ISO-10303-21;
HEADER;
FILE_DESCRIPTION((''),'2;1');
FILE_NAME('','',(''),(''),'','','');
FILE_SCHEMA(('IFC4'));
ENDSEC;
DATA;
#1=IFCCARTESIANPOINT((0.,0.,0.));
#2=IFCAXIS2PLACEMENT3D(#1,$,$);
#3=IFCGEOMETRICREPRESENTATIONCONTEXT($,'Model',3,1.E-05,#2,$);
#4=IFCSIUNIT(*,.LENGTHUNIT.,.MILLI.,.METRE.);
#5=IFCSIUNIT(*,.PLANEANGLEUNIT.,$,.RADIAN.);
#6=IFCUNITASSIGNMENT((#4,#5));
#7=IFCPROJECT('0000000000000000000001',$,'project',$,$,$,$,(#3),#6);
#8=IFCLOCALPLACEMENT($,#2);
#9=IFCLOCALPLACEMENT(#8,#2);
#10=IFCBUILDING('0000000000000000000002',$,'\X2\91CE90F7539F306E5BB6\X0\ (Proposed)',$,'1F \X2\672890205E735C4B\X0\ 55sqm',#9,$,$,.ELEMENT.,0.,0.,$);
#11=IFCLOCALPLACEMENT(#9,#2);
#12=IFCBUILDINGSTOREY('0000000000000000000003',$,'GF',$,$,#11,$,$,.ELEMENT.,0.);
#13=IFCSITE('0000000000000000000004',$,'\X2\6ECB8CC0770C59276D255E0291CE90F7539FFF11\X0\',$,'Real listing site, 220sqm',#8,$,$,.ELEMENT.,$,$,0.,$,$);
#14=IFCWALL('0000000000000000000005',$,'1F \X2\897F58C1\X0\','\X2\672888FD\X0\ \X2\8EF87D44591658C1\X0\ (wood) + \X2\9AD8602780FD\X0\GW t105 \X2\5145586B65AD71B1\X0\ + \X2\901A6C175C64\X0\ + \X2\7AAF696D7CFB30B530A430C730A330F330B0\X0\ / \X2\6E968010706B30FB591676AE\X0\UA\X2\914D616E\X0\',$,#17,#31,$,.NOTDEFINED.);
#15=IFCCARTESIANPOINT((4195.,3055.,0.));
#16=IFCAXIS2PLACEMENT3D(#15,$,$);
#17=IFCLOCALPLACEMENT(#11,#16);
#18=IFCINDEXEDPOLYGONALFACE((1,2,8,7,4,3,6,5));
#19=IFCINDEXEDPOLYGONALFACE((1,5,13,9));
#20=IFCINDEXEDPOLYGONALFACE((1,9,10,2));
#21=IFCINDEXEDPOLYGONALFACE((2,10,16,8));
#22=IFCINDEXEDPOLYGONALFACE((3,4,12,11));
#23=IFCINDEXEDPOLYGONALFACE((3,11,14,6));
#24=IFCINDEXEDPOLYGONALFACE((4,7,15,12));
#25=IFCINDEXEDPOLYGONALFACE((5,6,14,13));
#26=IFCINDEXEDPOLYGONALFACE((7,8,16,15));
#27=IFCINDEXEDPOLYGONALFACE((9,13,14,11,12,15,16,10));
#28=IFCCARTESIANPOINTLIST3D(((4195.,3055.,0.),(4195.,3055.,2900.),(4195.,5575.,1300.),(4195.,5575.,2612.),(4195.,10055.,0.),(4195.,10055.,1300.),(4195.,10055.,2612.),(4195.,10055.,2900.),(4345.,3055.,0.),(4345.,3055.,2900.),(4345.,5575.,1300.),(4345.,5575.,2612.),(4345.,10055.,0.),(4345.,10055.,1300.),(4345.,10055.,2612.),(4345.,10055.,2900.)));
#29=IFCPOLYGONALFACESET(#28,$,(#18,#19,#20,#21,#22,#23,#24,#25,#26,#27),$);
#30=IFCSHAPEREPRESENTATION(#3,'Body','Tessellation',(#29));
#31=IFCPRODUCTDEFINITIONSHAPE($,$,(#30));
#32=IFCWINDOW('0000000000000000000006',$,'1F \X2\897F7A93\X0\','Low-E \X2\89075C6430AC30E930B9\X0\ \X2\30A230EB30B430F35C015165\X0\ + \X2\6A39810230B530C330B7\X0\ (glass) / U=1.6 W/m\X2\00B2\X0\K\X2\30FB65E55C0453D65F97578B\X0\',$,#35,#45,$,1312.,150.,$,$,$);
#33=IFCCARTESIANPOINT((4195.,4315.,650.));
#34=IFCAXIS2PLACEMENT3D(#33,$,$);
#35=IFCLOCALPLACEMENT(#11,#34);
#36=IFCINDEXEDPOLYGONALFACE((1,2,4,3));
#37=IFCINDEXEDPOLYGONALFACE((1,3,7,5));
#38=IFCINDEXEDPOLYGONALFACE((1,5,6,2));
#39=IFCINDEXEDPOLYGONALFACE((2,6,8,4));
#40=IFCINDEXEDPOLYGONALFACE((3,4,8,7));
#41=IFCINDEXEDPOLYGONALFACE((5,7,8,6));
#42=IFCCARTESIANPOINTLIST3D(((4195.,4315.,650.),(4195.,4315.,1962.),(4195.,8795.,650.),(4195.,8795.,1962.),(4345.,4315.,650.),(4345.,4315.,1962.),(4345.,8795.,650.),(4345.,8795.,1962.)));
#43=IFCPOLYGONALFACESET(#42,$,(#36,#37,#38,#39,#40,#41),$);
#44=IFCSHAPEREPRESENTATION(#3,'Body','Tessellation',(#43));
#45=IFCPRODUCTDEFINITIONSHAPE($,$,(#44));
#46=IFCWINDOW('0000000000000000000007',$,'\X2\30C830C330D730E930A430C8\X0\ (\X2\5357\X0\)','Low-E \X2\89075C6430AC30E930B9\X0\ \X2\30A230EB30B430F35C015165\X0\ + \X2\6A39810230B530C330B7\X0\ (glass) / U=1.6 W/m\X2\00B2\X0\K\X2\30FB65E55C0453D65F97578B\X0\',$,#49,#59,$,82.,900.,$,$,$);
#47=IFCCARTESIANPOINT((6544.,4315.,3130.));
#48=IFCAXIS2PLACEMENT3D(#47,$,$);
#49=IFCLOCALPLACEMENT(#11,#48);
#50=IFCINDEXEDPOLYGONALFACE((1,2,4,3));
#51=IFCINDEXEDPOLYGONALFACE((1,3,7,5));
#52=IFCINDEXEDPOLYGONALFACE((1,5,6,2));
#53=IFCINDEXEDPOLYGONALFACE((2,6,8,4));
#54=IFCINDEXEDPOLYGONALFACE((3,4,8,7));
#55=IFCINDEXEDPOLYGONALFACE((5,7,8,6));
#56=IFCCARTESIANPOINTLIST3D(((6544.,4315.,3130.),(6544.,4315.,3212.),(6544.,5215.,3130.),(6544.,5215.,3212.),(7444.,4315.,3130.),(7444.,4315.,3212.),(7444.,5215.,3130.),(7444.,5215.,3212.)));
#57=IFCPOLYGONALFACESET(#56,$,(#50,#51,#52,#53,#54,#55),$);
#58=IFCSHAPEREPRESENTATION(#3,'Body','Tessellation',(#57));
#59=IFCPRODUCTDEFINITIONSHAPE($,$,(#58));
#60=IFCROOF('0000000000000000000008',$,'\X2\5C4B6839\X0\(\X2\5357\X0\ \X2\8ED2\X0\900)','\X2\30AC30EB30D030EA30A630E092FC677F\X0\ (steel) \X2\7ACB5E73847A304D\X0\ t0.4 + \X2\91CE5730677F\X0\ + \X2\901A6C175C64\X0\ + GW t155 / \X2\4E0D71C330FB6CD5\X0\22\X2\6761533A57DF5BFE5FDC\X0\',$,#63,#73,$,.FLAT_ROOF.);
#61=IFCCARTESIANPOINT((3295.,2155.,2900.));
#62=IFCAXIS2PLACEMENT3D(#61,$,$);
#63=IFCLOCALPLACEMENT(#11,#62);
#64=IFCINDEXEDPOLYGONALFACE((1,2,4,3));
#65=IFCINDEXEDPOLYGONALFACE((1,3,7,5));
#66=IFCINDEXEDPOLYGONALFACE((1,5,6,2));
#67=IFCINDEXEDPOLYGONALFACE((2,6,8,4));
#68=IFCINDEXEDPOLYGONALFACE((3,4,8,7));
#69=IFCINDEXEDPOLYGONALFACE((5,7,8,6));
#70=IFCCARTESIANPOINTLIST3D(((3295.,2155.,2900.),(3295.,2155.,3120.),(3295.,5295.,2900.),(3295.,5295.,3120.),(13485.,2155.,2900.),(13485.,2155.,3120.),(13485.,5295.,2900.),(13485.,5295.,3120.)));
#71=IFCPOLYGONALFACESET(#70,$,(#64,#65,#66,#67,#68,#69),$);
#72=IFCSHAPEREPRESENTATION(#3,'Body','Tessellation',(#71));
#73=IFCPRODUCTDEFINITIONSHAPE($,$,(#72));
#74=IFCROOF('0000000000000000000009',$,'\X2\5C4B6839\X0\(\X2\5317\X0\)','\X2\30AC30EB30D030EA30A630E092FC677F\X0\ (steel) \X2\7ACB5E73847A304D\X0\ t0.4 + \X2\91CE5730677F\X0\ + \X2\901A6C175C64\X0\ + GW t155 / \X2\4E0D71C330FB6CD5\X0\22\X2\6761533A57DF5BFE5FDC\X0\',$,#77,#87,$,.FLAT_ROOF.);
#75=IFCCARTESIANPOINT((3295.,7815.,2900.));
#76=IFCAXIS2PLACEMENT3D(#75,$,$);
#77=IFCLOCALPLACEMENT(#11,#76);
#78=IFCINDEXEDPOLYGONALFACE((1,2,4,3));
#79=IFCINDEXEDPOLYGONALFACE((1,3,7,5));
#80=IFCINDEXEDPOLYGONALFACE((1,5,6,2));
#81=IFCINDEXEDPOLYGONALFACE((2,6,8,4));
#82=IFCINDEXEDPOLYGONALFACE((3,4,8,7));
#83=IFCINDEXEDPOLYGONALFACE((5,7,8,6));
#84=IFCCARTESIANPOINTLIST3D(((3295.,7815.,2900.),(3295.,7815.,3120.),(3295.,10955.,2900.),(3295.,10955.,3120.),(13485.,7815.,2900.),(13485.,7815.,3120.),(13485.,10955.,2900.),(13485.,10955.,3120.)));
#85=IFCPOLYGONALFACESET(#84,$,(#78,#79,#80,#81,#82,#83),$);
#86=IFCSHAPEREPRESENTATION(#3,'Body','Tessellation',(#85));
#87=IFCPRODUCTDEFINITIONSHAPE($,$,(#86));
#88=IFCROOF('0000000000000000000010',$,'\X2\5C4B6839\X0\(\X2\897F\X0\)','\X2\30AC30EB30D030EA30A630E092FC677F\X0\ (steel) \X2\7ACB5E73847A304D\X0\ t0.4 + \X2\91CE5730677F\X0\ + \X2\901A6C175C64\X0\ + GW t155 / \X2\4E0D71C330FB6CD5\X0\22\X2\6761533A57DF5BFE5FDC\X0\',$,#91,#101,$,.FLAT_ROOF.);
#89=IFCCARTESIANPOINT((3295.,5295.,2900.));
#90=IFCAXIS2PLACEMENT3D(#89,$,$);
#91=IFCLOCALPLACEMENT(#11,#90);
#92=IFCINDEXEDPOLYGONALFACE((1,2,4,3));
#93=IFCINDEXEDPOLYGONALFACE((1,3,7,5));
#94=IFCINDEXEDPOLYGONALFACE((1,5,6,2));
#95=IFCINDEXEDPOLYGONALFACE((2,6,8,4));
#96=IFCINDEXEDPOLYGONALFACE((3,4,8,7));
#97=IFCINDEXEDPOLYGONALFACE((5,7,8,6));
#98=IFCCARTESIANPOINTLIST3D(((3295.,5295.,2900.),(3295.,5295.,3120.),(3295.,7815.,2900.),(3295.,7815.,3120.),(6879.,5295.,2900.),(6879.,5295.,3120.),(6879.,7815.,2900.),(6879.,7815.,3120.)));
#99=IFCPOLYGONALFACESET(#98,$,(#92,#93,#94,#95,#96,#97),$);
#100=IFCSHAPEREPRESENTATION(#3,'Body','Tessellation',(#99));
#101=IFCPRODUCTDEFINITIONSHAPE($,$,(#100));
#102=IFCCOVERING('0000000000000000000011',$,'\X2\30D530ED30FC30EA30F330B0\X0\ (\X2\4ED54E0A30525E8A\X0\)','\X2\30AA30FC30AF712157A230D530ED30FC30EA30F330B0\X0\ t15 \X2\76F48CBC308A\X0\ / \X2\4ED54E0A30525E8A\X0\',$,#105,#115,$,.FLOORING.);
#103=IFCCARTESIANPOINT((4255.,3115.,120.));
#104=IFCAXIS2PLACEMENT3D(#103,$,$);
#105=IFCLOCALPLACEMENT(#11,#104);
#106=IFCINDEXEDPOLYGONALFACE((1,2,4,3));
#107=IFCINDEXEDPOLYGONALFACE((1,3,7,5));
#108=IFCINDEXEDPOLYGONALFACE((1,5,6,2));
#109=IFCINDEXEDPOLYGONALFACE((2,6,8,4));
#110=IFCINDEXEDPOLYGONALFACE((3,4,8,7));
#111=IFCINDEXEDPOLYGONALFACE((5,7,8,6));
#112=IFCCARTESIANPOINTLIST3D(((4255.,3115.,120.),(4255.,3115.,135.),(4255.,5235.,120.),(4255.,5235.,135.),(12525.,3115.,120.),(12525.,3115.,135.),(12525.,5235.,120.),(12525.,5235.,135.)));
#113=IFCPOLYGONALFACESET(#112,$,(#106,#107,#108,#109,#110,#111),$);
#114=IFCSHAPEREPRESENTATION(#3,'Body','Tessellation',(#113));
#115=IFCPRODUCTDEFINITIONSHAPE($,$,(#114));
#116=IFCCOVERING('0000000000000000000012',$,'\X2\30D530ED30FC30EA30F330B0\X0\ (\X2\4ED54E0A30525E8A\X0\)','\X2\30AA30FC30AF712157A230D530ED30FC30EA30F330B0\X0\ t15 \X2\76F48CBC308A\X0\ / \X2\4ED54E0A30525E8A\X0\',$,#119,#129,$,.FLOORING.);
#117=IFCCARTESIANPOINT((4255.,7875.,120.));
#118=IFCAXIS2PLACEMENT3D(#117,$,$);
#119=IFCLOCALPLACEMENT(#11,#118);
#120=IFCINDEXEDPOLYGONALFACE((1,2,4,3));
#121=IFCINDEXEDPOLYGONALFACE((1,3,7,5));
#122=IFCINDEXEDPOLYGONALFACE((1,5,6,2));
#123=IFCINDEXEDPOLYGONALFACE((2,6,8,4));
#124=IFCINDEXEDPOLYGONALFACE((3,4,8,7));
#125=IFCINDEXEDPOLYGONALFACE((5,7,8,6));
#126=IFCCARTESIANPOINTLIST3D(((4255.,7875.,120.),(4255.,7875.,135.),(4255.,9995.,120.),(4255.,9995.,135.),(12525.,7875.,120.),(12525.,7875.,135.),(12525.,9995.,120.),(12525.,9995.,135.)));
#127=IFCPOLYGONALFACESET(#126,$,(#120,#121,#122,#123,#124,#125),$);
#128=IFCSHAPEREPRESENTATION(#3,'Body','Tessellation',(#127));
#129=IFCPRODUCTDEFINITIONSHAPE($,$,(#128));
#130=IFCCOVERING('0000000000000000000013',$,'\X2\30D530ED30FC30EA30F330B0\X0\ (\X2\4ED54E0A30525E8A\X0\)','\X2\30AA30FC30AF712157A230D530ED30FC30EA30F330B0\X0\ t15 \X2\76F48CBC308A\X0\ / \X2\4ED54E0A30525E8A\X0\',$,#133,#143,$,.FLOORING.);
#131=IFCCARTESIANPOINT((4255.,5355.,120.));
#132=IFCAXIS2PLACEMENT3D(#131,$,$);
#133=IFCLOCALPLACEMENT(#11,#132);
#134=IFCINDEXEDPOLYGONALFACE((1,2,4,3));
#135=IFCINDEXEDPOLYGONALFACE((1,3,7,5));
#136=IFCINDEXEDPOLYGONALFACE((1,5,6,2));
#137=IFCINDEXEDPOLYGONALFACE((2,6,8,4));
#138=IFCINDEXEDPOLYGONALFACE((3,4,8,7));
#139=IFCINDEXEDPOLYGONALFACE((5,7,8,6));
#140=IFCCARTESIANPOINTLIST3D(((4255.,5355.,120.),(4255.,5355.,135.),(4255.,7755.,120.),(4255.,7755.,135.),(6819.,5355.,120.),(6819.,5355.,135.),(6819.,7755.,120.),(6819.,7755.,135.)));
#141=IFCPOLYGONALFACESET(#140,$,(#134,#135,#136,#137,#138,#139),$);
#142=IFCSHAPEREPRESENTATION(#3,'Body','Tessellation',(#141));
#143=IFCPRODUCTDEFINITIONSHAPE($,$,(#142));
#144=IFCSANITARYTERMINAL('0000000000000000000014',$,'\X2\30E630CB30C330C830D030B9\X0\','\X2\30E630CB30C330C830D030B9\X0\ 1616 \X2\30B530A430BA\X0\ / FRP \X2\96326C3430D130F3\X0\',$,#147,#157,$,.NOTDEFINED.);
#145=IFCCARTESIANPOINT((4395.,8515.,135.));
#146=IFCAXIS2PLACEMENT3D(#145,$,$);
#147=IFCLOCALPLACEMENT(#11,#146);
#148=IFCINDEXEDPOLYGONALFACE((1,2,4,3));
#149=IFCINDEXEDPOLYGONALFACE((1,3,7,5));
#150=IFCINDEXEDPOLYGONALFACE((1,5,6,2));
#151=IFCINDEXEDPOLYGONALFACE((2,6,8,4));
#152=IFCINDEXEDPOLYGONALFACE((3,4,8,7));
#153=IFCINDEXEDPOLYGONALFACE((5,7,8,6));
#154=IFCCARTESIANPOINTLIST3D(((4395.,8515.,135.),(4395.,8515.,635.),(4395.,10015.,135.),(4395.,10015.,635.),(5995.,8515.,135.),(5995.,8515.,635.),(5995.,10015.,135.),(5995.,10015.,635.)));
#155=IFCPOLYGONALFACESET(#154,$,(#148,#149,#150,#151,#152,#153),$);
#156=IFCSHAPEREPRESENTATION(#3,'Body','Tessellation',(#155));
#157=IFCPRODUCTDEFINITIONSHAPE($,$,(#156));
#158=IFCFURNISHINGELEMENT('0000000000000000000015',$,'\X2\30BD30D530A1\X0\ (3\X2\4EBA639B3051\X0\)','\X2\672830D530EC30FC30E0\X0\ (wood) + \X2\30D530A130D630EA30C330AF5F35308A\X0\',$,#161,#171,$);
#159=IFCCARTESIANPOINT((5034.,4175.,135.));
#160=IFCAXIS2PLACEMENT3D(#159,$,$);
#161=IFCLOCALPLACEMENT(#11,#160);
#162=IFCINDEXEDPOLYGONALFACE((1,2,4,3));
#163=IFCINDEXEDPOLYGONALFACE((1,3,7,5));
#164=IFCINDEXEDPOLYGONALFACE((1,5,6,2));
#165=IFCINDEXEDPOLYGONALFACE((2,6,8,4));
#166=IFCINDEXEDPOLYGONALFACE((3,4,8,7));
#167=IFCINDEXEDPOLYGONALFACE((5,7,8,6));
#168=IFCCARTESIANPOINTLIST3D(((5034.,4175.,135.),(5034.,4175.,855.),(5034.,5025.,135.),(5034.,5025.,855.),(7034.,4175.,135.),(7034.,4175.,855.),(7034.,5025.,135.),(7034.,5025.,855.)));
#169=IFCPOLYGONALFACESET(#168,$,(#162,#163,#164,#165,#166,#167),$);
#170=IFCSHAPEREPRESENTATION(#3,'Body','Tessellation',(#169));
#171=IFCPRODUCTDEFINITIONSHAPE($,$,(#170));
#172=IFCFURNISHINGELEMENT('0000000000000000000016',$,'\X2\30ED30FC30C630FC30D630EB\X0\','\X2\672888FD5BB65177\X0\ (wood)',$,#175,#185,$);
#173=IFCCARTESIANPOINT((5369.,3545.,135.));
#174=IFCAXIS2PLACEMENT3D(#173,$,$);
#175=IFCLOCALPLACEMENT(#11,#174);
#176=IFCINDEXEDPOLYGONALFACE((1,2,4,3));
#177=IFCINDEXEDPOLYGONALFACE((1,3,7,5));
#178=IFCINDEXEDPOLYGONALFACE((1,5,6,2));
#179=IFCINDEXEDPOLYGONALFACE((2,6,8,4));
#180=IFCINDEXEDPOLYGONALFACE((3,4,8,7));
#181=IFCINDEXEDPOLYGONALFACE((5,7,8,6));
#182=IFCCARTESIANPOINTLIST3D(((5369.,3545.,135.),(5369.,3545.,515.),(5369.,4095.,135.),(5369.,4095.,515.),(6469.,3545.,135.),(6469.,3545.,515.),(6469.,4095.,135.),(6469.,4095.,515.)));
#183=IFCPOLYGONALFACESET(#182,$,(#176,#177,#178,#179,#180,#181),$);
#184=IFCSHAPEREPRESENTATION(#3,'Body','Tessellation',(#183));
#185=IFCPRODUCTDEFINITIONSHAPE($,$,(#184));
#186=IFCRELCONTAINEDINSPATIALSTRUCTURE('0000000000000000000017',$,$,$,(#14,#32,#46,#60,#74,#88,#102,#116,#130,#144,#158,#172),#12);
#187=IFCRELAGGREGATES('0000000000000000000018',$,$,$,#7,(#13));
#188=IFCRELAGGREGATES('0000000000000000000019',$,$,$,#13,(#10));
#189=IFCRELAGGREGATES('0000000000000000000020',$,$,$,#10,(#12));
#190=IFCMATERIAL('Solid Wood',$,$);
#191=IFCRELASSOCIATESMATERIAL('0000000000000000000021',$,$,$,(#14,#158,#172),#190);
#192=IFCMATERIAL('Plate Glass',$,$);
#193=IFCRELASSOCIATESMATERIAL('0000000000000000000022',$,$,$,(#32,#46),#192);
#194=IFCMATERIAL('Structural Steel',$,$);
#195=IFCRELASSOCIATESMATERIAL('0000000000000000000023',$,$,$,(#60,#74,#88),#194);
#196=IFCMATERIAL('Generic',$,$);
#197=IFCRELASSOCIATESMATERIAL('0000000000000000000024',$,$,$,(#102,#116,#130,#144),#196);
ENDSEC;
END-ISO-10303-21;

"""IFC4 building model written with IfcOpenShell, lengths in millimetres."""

from ifc_helpers import new_model, si_unit, frame, frame_2d, origin, place, context, project, spatial, rectangle, extrude, material, element, fill, save


model = new_model("IFC4")

# Units and contexts
model_context = context("Model", 3, precision=1e-05, world=origin())
ifc_project = project(units=[si_unit("LENGTHUNIT", "METRE", prefix="MILLI"), si_unit("PLANEANGLEUNIT", "RADIAN")], contexts=[model_context])

# Site, building, storey
site_placement = place(None, origin())
site = spatial("IfcSite", under=ifc_project, at=site_placement, Name="滋賀県大津市野郷原１", ObjectType="Real listing site, 220sqm", CompositionType="ELEMENT", RefElevation=0.0)
building_placement = place(site_placement, origin())
building = spatial("IfcBuilding", under=site, at=building_placement, Name="野郷原の家 (Proposed)", ObjectType="1F 木造平屋 55sqm", CompositionType="ELEMENT", ElevationOfRefHeight=0.0, ElevationOfTerrain=0.0)
storey_placement = place(building_placement, origin())
storey = spatial("IfcBuildingStorey", under=building, at=storey_placement, Name="GF", CompositionType="ELEMENT", Elevation=0.0)

# Shared definitions
ifc_material_1 = material(Name="Solid Wood")

# Shared definitions
ifc_material_2 = material(Name="Plate Glass")

# Wall, opening, window
wall_1_placement = place(storey_placement, frame((4195.0, 3055.0, 0.0)))
wall_1 = element("IfcWall", 1, at=wall_1_placement, inside=storey, material=ifc_material_1, Name="1F 西壁", Description="木製 軸組外壁 (wood) + 高性能GW t105 充填断熱 + 通気層 + 窯業系サイディング / 準耐火・外皮UA配慮", PredefinedType="NOTDEFINED", context=model_context, shape_type="SweptSolid", body=[
    extrude(rectangle(XDim=150.0, YDim=7000.0, at=frame_2d((75.0, 3500.0))), frame((4195.0, 3055.0, 0.0)), (0.0, 0.0, 1.0), 2900.0),
])
opening_1_placement = place(storey_placement, frame((4195.0, 4315.0, 650.0)))
opening_1 = element("IfcOpeningElement", 2, at=opening_1_placement, cuts=wall_1, PredefinedType="NOTDEFINED", context=model_context, shape_type="SweptSolid", body=[
    extrude(rectangle(XDim=150.0, YDim=4480.0, at=frame_2d((75.0, 2240.0))), frame((4195.0, 4315.0, 650.0)), (0.0, 0.0, 1.0), 1312.0),
])
window_1_placement = place(storey_placement, frame((4195.0, 4315.0, 650.0)))
window_1 = element("IfcWindow", 3, at=window_1_placement, inside=storey, material=ifc_material_2, Name="1F 西窓", Description="Low-E 複層ガラス アルゴン封入 + 樹脂サッシ (glass) / U=1.6 W/m²K・日射取得型", OverallHeight=1312.0, OverallWidth=150.0, context=model_context, shape_type="SweptSolid", body=[
    extrude(rectangle(XDim=150.0, YDim=4480.0, at=frame_2d((75.0, 2240.0))), frame((4195.0, 4315.0, 650.0)), (0.0, 0.0, 1.0), 1312.0),
])
fill(opening_1, window_1)

# Window
window_2_placement = place(storey_placement, frame((6544.0, 4315.0, 3130.0)))
element("IfcWindow", 4, at=window_2_placement, inside=storey, material=ifc_material_2, Name="トップライト (南)", Description="Low-E 複層ガラス アルゴン封入 + 樹脂サッシ (glass) / U=1.6 W/m²K・日射取得型", OverallHeight=82.0, OverallWidth=900.0, context=model_context, shape_type="SweptSolid", body=[
    extrude(rectangle(XDim=900.0, YDim=900.0, at=frame_2d((450.0, 450.0))), frame((6544.0, 4315.0, 3130.0)), (0.0, 0.0, 1.0), 82.0),
])

# Roofs
ifc_material_3 = material(Name="Structural Steel")
roof_1_placement = place(storey_placement, frame((3295.0, 2155.0, 2900.0)))
element("IfcRoof", 5, at=roof_1_placement, inside=storey, material=ifc_material_3, Name="屋根(南 軒900)", Description="ガルバリウム鋼板 (steel) 立平葺き t0.4 + 野地板 + 通気層 + GW t155 / 不燃・法22条区域対応", PredefinedType="FLAT_ROOF", context=model_context, shape_type="SweptSolid", body=[
    extrude(rectangle(XDim=10190.0, YDim=3140.0, at=frame_2d((5095.0, 1570.0))), frame((3295.0, 2155.0, 2900.0)), (0.0, 0.0, 1.0), 220.0),
])
roof_2_placement = place(storey_placement, frame((3295.0, 7815.0, 2900.0)))
element("IfcRoof", 6, at=roof_2_placement, inside=storey, material=ifc_material_3, Name="屋根(北)", Description="ガルバリウム鋼板 (steel) 立平葺き t0.4 + 野地板 + 通気層 + GW t155 / 不燃・法22条区域対応", PredefinedType="FLAT_ROOF", context=model_context, shape_type="SweptSolid", body=[
    extrude(rectangle(XDim=10190.0, YDim=3140.0, at=frame_2d((5095.0, 1570.0))), frame((3295.0, 7815.0, 2900.0)), (0.0, 0.0, 1.0), 220.0),
])
roof_3_placement = place(storey_placement, frame((3295.0, 5295.0, 2900.0)))
element("IfcRoof", 7, at=roof_3_placement, inside=storey, material=ifc_material_3, Name="屋根(西)", Description="ガルバリウム鋼板 (steel) 立平葺き t0.4 + 野地板 + 通気層 + GW t155 / 不燃・法22条区域対応", PredefinedType="FLAT_ROOF", context=model_context, shape_type="SweptSolid", body=[
    extrude(rectangle(XDim=3584.0, YDim=2520.0, at=frame_2d((1792.0, 1260.0))), frame((3295.0, 5295.0, 2900.0)), (0.0, 0.0, 1.0), 220.0),
])

# Coverings
ifc_material_4 = material(Name="Generic")
covering_1_placement = place(storey_placement, frame((4255.0, 3115.0, 120.0)))
element("IfcCovering", 8, at=covering_1_placement, inside=storey, material=ifc_material_4, Name="フローリング (仕上げ床)", Description="オーク無垢フローリング t15 直貼り / 仕上げ床", PredefinedType="FLOORING", context=model_context, shape_type="SweptSolid", body=[
    extrude(rectangle(XDim=8270.0, YDim=2120.0, at=frame_2d((4135.0, 1060.0))), frame((4255.0, 3115.0, 120.0)), (0.0, 0.0, 1.0), 15.0),
])
covering_2_placement = place(storey_placement, frame((4255.0, 7875.0, 120.0)))
element("IfcCovering", 9, at=covering_2_placement, inside=storey, material=ifc_material_4, Name="フローリング (仕上げ床)", Description="オーク無垢フローリング t15 直貼り / 仕上げ床", PredefinedType="FLOORING", context=model_context, shape_type="SweptSolid", body=[
    extrude(rectangle(XDim=8270.0, YDim=2120.0, at=frame_2d((4135.0, 1060.0))), frame((4255.0, 7875.0, 120.0)), (0.0, 0.0, 1.0), 15.0),
])
covering_3_placement = place(storey_placement, frame((4255.0, 5355.0, 120.0)))
element("IfcCovering", 10, at=covering_3_placement, inside=storey, material=ifc_material_4, Name="フローリング (仕上げ床)", Description="オーク無垢フローリング t15 直貼り / 仕上げ床", PredefinedType="FLOORING", context=model_context, shape_type="SweptSolid", body=[
    extrude(rectangle(XDim=2564.0, YDim=2400.0, at=frame_2d((1282.0, 1200.0))), frame((4255.0, 5355.0, 120.0)), (0.0, 0.0, 1.0), 15.0),
])

# Sanitary terminal
sanitary_terminal_placement = place(storey_placement, frame((4395.0, 8515.0, 135.0)))
element("IfcSanitaryTerminal", 11, at=sanitary_terminal_placement, inside=storey, material=ifc_material_4, Name="ユニットバス", Description="ユニットバス 1616 サイズ / FRP 防水パン", PredefinedType="NOTDEFINED", context=model_context, shape_type="SweptSolid", body=[
    extrude(rectangle(XDim=1600.0, YDim=1500.0, at=frame_2d((800.0, 750.0))), frame((4395.0, 8515.0, 135.0)), (0.0, 0.0, 1.0), 500.0),
])

# Furnishing elements
furnishing_1_placement = place(storey_placement, frame((5034.0, 4175.0, 135.0)))
element("IfcFurnishingElement", 12, at=furnishing_1_placement, inside=storey, material=ifc_material_1, Name="ソファ (3人掛け)", Description="木フレーム (wood) + ファブリック張り", context=model_context, shape_type="SweptSolid", body=[
    extrude(rectangle(XDim=2000.0, YDim=850.0, at=frame_2d((1000.0, 425.0))), frame((5034.0, 4175.0, 135.0)), (0.0, 0.0, 1.0), 720.0),
])
furnishing_2_placement = place(storey_placement, frame((5369.0, 3545.0, 135.0)))
element("IfcFurnishingElement", 13, at=furnishing_2_placement, inside=storey, material=ifc_material_1, Name="ローテーブル", Description="木製家具 (wood)", context=model_context, shape_type="SweptSolid", body=[
    extrude(rectangle(XDim=1100.0, YDim=550.0, at=frame_2d((550.0, 275.0))), frame((5369.0, 3545.0, 135.0)), (0.0, 0.0, 1.0), 380.0),
])

save(model, "model.ifc")
